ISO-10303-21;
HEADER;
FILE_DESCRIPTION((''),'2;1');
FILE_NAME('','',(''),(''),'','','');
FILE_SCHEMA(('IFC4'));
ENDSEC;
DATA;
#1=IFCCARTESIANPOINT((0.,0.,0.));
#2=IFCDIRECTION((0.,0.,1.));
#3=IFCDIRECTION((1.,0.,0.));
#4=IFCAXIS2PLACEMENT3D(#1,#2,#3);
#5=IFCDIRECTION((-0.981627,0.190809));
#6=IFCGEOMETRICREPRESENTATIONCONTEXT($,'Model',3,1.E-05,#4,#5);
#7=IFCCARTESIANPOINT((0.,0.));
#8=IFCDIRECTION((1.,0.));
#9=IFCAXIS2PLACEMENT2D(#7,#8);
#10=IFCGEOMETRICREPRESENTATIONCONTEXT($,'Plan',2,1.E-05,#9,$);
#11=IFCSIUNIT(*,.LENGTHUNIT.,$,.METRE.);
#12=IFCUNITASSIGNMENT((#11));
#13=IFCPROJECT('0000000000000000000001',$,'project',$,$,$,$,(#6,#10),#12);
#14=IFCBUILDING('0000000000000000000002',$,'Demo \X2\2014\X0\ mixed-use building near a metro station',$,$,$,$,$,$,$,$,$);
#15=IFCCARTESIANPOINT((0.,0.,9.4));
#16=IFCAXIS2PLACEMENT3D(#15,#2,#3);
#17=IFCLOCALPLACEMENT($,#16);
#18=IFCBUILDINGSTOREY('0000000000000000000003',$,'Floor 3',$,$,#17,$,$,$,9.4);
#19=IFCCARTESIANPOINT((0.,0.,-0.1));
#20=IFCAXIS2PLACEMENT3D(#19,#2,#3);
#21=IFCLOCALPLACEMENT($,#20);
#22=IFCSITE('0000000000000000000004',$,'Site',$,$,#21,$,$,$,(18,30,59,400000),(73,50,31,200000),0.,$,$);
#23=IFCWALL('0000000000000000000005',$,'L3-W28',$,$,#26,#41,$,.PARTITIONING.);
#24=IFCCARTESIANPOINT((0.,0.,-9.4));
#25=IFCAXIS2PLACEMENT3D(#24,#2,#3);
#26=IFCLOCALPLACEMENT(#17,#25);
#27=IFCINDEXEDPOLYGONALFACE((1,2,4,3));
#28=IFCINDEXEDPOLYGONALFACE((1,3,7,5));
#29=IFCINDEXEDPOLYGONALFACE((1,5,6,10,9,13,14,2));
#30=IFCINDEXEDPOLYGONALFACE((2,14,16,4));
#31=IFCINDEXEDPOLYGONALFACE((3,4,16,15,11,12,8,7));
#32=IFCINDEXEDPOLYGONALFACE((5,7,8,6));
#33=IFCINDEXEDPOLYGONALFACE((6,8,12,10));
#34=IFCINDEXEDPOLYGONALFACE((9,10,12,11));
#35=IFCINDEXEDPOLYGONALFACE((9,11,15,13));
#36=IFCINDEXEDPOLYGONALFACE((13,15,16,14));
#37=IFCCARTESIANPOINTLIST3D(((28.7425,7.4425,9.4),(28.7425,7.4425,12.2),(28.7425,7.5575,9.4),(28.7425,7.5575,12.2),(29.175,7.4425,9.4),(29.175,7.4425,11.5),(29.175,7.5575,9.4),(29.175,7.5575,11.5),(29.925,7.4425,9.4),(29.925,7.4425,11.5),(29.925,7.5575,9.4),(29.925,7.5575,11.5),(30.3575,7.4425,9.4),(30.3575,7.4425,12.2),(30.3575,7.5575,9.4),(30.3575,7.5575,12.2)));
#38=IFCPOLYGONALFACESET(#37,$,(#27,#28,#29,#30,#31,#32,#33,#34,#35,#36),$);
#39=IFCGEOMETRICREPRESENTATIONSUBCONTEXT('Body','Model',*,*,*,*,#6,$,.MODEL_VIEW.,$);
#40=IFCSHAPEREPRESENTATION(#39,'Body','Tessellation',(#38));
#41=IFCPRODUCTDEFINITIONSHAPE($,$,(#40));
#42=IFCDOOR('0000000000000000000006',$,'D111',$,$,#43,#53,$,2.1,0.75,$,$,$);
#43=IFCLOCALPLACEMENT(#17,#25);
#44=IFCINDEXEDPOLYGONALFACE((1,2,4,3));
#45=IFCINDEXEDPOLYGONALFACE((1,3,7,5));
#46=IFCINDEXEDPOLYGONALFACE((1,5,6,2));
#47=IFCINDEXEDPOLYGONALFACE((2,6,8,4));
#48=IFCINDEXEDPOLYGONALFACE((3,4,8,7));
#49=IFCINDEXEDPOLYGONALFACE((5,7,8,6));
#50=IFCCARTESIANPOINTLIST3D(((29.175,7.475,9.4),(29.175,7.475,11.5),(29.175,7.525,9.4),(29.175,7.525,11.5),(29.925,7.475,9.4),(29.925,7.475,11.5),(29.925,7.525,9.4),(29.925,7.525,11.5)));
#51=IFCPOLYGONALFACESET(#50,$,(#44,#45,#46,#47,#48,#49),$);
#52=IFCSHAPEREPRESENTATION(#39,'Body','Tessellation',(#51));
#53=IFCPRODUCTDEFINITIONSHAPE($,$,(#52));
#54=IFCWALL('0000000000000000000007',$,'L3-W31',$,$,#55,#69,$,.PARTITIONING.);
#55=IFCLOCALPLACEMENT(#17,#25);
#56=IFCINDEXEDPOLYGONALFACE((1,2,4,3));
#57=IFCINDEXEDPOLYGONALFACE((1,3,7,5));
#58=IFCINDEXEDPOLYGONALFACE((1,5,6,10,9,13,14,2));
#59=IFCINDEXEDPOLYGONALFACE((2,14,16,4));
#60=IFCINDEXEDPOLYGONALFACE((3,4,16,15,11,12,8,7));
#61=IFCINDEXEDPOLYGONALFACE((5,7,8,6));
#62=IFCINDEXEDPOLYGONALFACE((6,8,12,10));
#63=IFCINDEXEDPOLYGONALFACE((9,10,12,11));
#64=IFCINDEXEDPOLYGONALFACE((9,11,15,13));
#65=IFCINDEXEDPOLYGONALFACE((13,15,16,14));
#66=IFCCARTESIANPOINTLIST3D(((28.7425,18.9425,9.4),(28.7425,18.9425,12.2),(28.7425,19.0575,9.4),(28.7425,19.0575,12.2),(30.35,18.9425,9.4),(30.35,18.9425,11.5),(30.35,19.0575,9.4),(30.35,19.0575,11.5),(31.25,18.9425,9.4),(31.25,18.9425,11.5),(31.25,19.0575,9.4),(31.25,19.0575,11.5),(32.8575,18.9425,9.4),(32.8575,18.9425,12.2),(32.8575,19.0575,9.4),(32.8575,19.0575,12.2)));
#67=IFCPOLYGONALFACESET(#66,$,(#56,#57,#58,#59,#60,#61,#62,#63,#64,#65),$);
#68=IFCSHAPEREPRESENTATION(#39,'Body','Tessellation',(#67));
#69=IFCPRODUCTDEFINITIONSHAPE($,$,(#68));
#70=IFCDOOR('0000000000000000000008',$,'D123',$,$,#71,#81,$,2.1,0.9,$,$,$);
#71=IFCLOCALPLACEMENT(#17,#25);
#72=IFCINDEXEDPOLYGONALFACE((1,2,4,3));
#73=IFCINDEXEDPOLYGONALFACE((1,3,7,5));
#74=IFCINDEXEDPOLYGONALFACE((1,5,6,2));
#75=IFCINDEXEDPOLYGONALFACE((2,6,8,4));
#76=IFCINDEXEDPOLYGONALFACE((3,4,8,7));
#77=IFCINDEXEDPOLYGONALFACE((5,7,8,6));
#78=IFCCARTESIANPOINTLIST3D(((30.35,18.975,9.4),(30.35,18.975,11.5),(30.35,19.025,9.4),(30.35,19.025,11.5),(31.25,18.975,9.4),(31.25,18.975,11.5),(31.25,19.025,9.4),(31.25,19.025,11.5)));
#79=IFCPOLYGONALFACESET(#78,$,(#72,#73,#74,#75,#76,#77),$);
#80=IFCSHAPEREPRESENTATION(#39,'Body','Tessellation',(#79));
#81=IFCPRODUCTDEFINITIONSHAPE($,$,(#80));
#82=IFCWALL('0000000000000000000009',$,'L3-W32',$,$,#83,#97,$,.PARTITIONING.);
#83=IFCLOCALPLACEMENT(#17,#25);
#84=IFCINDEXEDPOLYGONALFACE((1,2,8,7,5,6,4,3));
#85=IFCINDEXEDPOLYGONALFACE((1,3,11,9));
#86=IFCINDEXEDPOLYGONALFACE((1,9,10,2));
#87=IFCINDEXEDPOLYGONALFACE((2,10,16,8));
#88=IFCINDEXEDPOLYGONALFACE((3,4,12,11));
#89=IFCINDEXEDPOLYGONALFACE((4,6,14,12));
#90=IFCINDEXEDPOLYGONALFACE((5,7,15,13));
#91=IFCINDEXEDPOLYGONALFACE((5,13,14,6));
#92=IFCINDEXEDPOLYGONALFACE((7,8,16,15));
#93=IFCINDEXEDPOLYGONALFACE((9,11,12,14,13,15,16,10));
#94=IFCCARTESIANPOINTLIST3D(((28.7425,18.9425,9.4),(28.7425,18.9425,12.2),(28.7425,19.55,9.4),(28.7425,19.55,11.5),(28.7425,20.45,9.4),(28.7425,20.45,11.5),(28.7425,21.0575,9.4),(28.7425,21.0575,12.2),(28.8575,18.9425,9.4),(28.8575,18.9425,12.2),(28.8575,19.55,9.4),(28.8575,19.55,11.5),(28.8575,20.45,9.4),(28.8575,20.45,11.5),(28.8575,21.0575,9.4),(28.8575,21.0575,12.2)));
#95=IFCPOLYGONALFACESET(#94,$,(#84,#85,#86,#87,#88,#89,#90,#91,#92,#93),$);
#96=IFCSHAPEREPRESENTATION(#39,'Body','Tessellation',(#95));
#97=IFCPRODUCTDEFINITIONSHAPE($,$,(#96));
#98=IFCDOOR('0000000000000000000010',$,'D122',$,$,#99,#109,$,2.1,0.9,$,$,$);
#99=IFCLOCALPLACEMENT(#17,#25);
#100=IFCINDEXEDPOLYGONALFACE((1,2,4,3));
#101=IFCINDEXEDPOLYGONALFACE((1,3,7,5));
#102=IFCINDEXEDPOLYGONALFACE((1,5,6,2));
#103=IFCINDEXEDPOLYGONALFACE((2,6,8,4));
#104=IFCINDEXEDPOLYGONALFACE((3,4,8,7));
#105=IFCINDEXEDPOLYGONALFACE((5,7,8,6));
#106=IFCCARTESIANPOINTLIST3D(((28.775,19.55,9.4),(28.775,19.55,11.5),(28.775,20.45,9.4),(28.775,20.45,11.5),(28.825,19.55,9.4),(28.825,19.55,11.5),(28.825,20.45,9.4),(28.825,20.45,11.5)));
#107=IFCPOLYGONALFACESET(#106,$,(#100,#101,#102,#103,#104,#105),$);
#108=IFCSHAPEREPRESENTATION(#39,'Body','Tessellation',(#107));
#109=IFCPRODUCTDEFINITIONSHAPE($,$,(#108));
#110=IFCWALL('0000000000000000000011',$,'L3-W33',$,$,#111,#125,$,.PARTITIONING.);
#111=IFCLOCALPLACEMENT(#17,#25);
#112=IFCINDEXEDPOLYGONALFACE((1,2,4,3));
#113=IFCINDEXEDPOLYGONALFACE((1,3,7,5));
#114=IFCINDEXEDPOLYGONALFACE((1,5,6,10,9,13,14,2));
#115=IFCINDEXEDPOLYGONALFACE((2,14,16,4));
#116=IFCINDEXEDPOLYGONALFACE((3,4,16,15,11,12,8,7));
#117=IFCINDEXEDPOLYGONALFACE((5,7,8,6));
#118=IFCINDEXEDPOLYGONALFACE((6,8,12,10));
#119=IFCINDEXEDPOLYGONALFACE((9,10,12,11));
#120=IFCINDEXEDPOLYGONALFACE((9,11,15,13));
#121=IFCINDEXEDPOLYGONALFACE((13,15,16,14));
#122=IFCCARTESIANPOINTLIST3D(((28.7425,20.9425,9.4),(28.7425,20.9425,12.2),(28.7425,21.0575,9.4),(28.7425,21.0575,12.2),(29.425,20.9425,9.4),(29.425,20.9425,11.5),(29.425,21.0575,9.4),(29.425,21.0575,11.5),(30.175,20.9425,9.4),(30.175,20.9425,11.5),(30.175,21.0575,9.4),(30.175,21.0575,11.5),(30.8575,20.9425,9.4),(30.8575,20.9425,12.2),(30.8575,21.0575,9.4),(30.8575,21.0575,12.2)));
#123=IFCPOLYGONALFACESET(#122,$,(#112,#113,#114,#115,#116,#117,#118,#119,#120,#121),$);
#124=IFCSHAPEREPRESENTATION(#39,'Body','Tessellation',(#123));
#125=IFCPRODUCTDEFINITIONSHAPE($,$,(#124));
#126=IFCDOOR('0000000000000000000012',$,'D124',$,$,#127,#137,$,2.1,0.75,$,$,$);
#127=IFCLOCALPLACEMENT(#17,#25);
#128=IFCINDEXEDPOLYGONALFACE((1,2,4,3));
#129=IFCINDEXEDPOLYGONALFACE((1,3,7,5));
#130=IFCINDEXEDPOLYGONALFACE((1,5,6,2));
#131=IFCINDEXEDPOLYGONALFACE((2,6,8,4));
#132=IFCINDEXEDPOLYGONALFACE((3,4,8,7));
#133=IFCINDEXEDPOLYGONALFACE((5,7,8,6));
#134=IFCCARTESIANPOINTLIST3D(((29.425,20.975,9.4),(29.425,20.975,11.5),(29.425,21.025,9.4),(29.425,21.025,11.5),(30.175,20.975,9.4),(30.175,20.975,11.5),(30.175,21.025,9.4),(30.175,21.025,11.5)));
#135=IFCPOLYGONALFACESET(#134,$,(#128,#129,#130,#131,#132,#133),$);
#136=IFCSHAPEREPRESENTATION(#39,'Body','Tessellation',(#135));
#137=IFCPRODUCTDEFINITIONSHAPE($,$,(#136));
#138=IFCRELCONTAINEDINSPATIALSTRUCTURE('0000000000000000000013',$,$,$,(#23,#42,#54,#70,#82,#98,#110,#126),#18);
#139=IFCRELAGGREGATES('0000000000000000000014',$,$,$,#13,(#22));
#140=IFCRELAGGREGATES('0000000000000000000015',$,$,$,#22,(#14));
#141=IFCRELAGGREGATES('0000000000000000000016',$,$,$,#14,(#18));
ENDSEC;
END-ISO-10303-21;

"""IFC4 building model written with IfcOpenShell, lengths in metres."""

from ifc_helpers import new_model, si_unit, direction, frame, origin_with_axes, origin_2d_with_axis, place, context, subcontext, project, spatial, line, indexed_curve, outline, extrude, element, fill, save


model = new_model("IFC4")

# Units and contexts
model_context = context("Model", 3, precision=1e-05, world=origin_with_axes(), true_north=direction((-0.981627, 0.190809)))
plan_context = context("Plan", 2, precision=1e-05, world=origin_2d_with_axis())
body_context = subcontext(model_context, "Body", "Model", "MODEL_VIEW")
ifc_project = project(units=[si_unit("LENGTHUNIT", "METRE")], contexts=[model_context, plan_context])

# Site, building, storey
site_placement = place(None, frame((0.0, 0.0, -0.1), z_axis=(0.0, 0.0, 1.0), x_axis=(1.0, 0.0, 0.0)))
site = spatial("IfcSite", under=ifc_project, at=site_placement, Name="Site", RefLatitude=(18, 30, 59, 400000), RefLongitude=(73, 50, 31, 200000), RefElevation=0.0)
building = spatial("IfcBuilding", under=site, Name="Demo — mixed-use building near a metro station")
storey_placement = place(None, frame((0.0, 0.0, 9.4), z_axis=(0.0, 0.0, 1.0), x_axis=(1.0, 0.0, 0.0)))
storey = spatial("IfcBuildingStorey", under=building, at=storey_placement, Name="Floor 3", Elevation=9.4)

# Wall, opening, door
wall_1_placement = place(storey_placement, frame((0.0, 0.0, -9.4), z_axis=(0.0, 0.0, 1.0), x_axis=(1.0, 0.0, 0.0)))
wall_1 = element("IfcWall", 1, at=wall_1_placement, inside=storey, Name="L3-W28", PredefinedType="PARTITIONING", context=body_context, shape_type="SweptSolid", body=[
    extrude(outline(indexed_curve([(30.3575, 7.4425), (28.7425, 7.4425), (28.7425, 7.5575), (30.3575, 7.5575)], segments=[line(1, 2, 3, 4, 1)])), frame((0.0, 0.0, 9.4), z_axis=(0.0, 0.0, 1.0), x_axis=(1.0, 0.0, 0.0)), (0.0, 0.0, 1.0), 2.8),
])
opening_1_placement = place(wall_1_placement, origin_with_axes())
opening_1 = element("IfcOpeningElement", 2, at=opening_1_placement, cuts=wall_1, context=body_context, shape_type="SweptSolid", body=[
    extrude(outline(indexed_curve([(29.925, 7.3925), (29.175, 7.3925), (29.175, 7.6075), (29.925, 7.6075)], segments=[line(1, 2, 3, 4, 1)])), frame((0.0, 0.0, 9.4), z_axis=(0.0, 0.0, 1.0), x_axis=(1.0, 0.0, 0.0)), (0.0, 0.0, 1.0), 2.1),
])
door_1_placement = place(storey_placement, frame((0.0, 0.0, -9.4), z_axis=(0.0, 0.0, 1.0), x_axis=(1.0, 0.0, 0.0)))
door_1 = element("IfcDoor", 3, at=door_1_placement, inside=storey, Name="D111", OverallHeight=2.1, OverallWidth=0.75, context=body_context, shape_type="SweptSolid", body=[
    extrude(outline(indexed_curve([(29.925, 7.475), (29.175, 7.475), (29.175, 7.525), (29.925, 7.525)], segments=[line(1, 2, 3, 4, 1)])), frame((0.0, 0.0, 9.4), z_axis=(0.0, 0.0, 1.0), x_axis=(1.0, 0.0, 0.0)), (0.0, 0.0, 1.0), 2.1),
])
fill(opening_1, door_1)

# Walls, openings, doors
wall_2_placement = place(storey_placement, frame((0.0, 0.0, -9.4), z_axis=(0.0, 0.0, 1.0), x_axis=(1.0, 0.0, 0.0)))
wall_2 = element("IfcWall", 4, at=wall_2_placement, inside=storey, Name="L3-W31", PredefinedType="PARTITIONING", context=body_context, shape_type="SweptSolid", body=[
    extrude(outline(indexed_curve([(32.8575, 18.9425), (28.7425, 18.9425), (28.7425, 19.0575), (32.8575, 19.0575)], segments=[line(1, 2, 3, 4, 1)])), frame((0.0, 0.0, 9.4), z_axis=(0.0, 0.0, 1.0), x_axis=(1.0, 0.0, 0.0)), (0.0, 0.0, 1.0), 2.8),
])
opening_2_placement = place(wall_2_placement, origin_with_axes())
opening_2 = element("IfcOpeningElement", 5, at=opening_2_placement, cuts=wall_2, context=body_context, shape_type="SweptSolid", body=[
    extrude(outline(indexed_curve([(31.25, 18.8925), (30.35, 18.8925), (30.35, 19.1075), (31.25, 19.1075)], segments=[line(1, 2, 3, 4, 1)])), frame((0.0, 0.0, 9.4), z_axis=(0.0, 0.0, 1.0), x_axis=(1.0, 0.0, 0.0)), (0.0, 0.0, 1.0), 2.1),
])
door_2_placement = place(storey_placement, frame((0.0, 0.0, -9.4), z_axis=(0.0, 0.0, 1.0), x_axis=(1.0, 0.0, 0.0)))
door_2 = element("IfcDoor", 6, at=door_2_placement, inside=storey, Name="D123", OverallHeight=2.1, OverallWidth=0.9, context=body_context, shape_type="SweptSolid", body=[
    extrude(outline(indexed_curve([(31.25, 18.975), (30.35, 18.975), (30.35, 19.025), (31.25, 19.025)], segments=[line(1, 2, 3, 4, 1)])), frame((0.0, 0.0, 9.4), z_axis=(0.0, 0.0, 1.0), x_axis=(1.0, 0.0, 0.0)), (0.0, 0.0, 1.0), 2.1),
])
fill(opening_2, door_2)
wall_3_placement = place(storey_placement, frame((0.0, 0.0, -9.4), z_axis=(0.0, 0.0, 1.0), x_axis=(1.0, 0.0, 0.0)))
wall_3 = element("IfcWall", 7, at=wall_3_placement, inside=storey, Name="L3-W32", PredefinedType="PARTITIONING", context=body_context, shape_type="SweptSolid", body=[
    extrude(outline(indexed_curve([(28.7425, 18.9425), (28.7425, 21.0575), (28.8575, 21.0575), (28.8575, 18.9425)], segments=[line(1, 2, 3, 4, 1)])), frame((0.0, 0.0, 9.4), z_axis=(0.0, 0.0, 1.0), x_axis=(1.0, 0.0, 0.0)), (0.0, 0.0, 1.0), 2.8),
])
opening_3_placement = place(wall_3_placement, origin_with_axes())
opening_3 = element("IfcOpeningElement", 8, at=opening_3_placement, cuts=wall_3, context=body_context, shape_type="SweptSolid", body=[
    extrude(outline(indexed_curve([(28.6925, 19.55), (28.6925, 20.45), (28.9075, 20.45), (28.9075, 19.55)], segments=[line(1, 2, 3, 4, 1)])), frame((0.0, 0.0, 9.4), z_axis=(0.0, 0.0, 1.0), x_axis=(1.0, 0.0, 0.0)), (0.0, 0.0, 1.0), 2.1),
])
door_3_placement = place(storey_placement, frame((0.0, 0.0, -9.4), z_axis=(0.0, 0.0, 1.0), x_axis=(1.0, 0.0, 0.0)))
door_3 = element("IfcDoor", 9, at=door_3_placement, inside=storey, Name="D122", OverallHeight=2.1, OverallWidth=0.9, context=body_context, shape_type="SweptSolid", body=[
    extrude(outline(indexed_curve([(28.775, 19.55), (28.775, 20.45), (28.825, 20.45), (28.825, 19.55)], segments=[line(1, 2, 3, 4, 1)])), frame((0.0, 0.0, 9.4), z_axis=(0.0, 0.0, 1.0), x_axis=(1.0, 0.0, 0.0)), (0.0, 0.0, 1.0), 2.1),
])
fill(opening_3, door_3)
wall_4_placement = place(storey_placement, frame((0.0, 0.0, -9.4), z_axis=(0.0, 0.0, 1.0), x_axis=(1.0, 0.0, 0.0)))
wall_4 = element("IfcWall", 10, at=wall_4_placement, inside=storey, Name="L3-W33", PredefinedType="PARTITIONING", context=body_context, shape_type="SweptSolid", body=[
    extrude(outline(indexed_curve([(30.8575, 20.9425), (28.7425, 20.9425), (28.7425, 21.0575), (30.8575, 21.0575)], segments=[line(1, 2, 3, 4, 1)])), frame((0.0, 0.0, 9.4), z_axis=(0.0, 0.0, 1.0), x_axis=(1.0, 0.0, 0.0)), (0.0, 0.0, 1.0), 2.8),
])
opening_4_placement = place(wall_4_placement, origin_with_axes())
opening_4 = element("IfcOpeningElement", 11, at=opening_4_placement, cuts=wall_4, context=body_context, shape_type="SweptSolid", body=[
    extrude(outline(indexed_curve([(30.175, 20.8925), (29.425, 20.8925), (29.425, 21.1075), (30.175, 21.1075)], segments=[line(1, 2, 3, 4, 1)])), frame((0.0, 0.0, 9.4), z_axis=(0.0, 0.0, 1.0), x_axis=(1.0, 0.0, 0.0)), (0.0, 0.0, 1.0), 2.1),
])
door_4_placement = place(storey_placement, frame((0.0, 0.0, -9.4), z_axis=(0.0, 0.0, 1.0), x_axis=(1.0, 0.0, 0.0)))
door_4 = element("IfcDoor", 12, at=door_4_placement, inside=storey, Name="D124", OverallHeight=2.1, OverallWidth=0.75, context=body_context, shape_type="SweptSolid", body=[
    extrude(outline(indexed_curve([(30.175, 20.975), (29.425, 20.975), (29.425, 21.025), (30.175, 21.025)], segments=[line(1, 2, 3, 4, 1)])), frame((0.0, 0.0, 9.4), z_axis=(0.0, 0.0, 1.0), x_axis=(1.0, 0.0, 0.0)), (0.0, 0.0, 1.0), 2.1),
])
fill(opening_4, door_4)

save(model, "model.ifc")
